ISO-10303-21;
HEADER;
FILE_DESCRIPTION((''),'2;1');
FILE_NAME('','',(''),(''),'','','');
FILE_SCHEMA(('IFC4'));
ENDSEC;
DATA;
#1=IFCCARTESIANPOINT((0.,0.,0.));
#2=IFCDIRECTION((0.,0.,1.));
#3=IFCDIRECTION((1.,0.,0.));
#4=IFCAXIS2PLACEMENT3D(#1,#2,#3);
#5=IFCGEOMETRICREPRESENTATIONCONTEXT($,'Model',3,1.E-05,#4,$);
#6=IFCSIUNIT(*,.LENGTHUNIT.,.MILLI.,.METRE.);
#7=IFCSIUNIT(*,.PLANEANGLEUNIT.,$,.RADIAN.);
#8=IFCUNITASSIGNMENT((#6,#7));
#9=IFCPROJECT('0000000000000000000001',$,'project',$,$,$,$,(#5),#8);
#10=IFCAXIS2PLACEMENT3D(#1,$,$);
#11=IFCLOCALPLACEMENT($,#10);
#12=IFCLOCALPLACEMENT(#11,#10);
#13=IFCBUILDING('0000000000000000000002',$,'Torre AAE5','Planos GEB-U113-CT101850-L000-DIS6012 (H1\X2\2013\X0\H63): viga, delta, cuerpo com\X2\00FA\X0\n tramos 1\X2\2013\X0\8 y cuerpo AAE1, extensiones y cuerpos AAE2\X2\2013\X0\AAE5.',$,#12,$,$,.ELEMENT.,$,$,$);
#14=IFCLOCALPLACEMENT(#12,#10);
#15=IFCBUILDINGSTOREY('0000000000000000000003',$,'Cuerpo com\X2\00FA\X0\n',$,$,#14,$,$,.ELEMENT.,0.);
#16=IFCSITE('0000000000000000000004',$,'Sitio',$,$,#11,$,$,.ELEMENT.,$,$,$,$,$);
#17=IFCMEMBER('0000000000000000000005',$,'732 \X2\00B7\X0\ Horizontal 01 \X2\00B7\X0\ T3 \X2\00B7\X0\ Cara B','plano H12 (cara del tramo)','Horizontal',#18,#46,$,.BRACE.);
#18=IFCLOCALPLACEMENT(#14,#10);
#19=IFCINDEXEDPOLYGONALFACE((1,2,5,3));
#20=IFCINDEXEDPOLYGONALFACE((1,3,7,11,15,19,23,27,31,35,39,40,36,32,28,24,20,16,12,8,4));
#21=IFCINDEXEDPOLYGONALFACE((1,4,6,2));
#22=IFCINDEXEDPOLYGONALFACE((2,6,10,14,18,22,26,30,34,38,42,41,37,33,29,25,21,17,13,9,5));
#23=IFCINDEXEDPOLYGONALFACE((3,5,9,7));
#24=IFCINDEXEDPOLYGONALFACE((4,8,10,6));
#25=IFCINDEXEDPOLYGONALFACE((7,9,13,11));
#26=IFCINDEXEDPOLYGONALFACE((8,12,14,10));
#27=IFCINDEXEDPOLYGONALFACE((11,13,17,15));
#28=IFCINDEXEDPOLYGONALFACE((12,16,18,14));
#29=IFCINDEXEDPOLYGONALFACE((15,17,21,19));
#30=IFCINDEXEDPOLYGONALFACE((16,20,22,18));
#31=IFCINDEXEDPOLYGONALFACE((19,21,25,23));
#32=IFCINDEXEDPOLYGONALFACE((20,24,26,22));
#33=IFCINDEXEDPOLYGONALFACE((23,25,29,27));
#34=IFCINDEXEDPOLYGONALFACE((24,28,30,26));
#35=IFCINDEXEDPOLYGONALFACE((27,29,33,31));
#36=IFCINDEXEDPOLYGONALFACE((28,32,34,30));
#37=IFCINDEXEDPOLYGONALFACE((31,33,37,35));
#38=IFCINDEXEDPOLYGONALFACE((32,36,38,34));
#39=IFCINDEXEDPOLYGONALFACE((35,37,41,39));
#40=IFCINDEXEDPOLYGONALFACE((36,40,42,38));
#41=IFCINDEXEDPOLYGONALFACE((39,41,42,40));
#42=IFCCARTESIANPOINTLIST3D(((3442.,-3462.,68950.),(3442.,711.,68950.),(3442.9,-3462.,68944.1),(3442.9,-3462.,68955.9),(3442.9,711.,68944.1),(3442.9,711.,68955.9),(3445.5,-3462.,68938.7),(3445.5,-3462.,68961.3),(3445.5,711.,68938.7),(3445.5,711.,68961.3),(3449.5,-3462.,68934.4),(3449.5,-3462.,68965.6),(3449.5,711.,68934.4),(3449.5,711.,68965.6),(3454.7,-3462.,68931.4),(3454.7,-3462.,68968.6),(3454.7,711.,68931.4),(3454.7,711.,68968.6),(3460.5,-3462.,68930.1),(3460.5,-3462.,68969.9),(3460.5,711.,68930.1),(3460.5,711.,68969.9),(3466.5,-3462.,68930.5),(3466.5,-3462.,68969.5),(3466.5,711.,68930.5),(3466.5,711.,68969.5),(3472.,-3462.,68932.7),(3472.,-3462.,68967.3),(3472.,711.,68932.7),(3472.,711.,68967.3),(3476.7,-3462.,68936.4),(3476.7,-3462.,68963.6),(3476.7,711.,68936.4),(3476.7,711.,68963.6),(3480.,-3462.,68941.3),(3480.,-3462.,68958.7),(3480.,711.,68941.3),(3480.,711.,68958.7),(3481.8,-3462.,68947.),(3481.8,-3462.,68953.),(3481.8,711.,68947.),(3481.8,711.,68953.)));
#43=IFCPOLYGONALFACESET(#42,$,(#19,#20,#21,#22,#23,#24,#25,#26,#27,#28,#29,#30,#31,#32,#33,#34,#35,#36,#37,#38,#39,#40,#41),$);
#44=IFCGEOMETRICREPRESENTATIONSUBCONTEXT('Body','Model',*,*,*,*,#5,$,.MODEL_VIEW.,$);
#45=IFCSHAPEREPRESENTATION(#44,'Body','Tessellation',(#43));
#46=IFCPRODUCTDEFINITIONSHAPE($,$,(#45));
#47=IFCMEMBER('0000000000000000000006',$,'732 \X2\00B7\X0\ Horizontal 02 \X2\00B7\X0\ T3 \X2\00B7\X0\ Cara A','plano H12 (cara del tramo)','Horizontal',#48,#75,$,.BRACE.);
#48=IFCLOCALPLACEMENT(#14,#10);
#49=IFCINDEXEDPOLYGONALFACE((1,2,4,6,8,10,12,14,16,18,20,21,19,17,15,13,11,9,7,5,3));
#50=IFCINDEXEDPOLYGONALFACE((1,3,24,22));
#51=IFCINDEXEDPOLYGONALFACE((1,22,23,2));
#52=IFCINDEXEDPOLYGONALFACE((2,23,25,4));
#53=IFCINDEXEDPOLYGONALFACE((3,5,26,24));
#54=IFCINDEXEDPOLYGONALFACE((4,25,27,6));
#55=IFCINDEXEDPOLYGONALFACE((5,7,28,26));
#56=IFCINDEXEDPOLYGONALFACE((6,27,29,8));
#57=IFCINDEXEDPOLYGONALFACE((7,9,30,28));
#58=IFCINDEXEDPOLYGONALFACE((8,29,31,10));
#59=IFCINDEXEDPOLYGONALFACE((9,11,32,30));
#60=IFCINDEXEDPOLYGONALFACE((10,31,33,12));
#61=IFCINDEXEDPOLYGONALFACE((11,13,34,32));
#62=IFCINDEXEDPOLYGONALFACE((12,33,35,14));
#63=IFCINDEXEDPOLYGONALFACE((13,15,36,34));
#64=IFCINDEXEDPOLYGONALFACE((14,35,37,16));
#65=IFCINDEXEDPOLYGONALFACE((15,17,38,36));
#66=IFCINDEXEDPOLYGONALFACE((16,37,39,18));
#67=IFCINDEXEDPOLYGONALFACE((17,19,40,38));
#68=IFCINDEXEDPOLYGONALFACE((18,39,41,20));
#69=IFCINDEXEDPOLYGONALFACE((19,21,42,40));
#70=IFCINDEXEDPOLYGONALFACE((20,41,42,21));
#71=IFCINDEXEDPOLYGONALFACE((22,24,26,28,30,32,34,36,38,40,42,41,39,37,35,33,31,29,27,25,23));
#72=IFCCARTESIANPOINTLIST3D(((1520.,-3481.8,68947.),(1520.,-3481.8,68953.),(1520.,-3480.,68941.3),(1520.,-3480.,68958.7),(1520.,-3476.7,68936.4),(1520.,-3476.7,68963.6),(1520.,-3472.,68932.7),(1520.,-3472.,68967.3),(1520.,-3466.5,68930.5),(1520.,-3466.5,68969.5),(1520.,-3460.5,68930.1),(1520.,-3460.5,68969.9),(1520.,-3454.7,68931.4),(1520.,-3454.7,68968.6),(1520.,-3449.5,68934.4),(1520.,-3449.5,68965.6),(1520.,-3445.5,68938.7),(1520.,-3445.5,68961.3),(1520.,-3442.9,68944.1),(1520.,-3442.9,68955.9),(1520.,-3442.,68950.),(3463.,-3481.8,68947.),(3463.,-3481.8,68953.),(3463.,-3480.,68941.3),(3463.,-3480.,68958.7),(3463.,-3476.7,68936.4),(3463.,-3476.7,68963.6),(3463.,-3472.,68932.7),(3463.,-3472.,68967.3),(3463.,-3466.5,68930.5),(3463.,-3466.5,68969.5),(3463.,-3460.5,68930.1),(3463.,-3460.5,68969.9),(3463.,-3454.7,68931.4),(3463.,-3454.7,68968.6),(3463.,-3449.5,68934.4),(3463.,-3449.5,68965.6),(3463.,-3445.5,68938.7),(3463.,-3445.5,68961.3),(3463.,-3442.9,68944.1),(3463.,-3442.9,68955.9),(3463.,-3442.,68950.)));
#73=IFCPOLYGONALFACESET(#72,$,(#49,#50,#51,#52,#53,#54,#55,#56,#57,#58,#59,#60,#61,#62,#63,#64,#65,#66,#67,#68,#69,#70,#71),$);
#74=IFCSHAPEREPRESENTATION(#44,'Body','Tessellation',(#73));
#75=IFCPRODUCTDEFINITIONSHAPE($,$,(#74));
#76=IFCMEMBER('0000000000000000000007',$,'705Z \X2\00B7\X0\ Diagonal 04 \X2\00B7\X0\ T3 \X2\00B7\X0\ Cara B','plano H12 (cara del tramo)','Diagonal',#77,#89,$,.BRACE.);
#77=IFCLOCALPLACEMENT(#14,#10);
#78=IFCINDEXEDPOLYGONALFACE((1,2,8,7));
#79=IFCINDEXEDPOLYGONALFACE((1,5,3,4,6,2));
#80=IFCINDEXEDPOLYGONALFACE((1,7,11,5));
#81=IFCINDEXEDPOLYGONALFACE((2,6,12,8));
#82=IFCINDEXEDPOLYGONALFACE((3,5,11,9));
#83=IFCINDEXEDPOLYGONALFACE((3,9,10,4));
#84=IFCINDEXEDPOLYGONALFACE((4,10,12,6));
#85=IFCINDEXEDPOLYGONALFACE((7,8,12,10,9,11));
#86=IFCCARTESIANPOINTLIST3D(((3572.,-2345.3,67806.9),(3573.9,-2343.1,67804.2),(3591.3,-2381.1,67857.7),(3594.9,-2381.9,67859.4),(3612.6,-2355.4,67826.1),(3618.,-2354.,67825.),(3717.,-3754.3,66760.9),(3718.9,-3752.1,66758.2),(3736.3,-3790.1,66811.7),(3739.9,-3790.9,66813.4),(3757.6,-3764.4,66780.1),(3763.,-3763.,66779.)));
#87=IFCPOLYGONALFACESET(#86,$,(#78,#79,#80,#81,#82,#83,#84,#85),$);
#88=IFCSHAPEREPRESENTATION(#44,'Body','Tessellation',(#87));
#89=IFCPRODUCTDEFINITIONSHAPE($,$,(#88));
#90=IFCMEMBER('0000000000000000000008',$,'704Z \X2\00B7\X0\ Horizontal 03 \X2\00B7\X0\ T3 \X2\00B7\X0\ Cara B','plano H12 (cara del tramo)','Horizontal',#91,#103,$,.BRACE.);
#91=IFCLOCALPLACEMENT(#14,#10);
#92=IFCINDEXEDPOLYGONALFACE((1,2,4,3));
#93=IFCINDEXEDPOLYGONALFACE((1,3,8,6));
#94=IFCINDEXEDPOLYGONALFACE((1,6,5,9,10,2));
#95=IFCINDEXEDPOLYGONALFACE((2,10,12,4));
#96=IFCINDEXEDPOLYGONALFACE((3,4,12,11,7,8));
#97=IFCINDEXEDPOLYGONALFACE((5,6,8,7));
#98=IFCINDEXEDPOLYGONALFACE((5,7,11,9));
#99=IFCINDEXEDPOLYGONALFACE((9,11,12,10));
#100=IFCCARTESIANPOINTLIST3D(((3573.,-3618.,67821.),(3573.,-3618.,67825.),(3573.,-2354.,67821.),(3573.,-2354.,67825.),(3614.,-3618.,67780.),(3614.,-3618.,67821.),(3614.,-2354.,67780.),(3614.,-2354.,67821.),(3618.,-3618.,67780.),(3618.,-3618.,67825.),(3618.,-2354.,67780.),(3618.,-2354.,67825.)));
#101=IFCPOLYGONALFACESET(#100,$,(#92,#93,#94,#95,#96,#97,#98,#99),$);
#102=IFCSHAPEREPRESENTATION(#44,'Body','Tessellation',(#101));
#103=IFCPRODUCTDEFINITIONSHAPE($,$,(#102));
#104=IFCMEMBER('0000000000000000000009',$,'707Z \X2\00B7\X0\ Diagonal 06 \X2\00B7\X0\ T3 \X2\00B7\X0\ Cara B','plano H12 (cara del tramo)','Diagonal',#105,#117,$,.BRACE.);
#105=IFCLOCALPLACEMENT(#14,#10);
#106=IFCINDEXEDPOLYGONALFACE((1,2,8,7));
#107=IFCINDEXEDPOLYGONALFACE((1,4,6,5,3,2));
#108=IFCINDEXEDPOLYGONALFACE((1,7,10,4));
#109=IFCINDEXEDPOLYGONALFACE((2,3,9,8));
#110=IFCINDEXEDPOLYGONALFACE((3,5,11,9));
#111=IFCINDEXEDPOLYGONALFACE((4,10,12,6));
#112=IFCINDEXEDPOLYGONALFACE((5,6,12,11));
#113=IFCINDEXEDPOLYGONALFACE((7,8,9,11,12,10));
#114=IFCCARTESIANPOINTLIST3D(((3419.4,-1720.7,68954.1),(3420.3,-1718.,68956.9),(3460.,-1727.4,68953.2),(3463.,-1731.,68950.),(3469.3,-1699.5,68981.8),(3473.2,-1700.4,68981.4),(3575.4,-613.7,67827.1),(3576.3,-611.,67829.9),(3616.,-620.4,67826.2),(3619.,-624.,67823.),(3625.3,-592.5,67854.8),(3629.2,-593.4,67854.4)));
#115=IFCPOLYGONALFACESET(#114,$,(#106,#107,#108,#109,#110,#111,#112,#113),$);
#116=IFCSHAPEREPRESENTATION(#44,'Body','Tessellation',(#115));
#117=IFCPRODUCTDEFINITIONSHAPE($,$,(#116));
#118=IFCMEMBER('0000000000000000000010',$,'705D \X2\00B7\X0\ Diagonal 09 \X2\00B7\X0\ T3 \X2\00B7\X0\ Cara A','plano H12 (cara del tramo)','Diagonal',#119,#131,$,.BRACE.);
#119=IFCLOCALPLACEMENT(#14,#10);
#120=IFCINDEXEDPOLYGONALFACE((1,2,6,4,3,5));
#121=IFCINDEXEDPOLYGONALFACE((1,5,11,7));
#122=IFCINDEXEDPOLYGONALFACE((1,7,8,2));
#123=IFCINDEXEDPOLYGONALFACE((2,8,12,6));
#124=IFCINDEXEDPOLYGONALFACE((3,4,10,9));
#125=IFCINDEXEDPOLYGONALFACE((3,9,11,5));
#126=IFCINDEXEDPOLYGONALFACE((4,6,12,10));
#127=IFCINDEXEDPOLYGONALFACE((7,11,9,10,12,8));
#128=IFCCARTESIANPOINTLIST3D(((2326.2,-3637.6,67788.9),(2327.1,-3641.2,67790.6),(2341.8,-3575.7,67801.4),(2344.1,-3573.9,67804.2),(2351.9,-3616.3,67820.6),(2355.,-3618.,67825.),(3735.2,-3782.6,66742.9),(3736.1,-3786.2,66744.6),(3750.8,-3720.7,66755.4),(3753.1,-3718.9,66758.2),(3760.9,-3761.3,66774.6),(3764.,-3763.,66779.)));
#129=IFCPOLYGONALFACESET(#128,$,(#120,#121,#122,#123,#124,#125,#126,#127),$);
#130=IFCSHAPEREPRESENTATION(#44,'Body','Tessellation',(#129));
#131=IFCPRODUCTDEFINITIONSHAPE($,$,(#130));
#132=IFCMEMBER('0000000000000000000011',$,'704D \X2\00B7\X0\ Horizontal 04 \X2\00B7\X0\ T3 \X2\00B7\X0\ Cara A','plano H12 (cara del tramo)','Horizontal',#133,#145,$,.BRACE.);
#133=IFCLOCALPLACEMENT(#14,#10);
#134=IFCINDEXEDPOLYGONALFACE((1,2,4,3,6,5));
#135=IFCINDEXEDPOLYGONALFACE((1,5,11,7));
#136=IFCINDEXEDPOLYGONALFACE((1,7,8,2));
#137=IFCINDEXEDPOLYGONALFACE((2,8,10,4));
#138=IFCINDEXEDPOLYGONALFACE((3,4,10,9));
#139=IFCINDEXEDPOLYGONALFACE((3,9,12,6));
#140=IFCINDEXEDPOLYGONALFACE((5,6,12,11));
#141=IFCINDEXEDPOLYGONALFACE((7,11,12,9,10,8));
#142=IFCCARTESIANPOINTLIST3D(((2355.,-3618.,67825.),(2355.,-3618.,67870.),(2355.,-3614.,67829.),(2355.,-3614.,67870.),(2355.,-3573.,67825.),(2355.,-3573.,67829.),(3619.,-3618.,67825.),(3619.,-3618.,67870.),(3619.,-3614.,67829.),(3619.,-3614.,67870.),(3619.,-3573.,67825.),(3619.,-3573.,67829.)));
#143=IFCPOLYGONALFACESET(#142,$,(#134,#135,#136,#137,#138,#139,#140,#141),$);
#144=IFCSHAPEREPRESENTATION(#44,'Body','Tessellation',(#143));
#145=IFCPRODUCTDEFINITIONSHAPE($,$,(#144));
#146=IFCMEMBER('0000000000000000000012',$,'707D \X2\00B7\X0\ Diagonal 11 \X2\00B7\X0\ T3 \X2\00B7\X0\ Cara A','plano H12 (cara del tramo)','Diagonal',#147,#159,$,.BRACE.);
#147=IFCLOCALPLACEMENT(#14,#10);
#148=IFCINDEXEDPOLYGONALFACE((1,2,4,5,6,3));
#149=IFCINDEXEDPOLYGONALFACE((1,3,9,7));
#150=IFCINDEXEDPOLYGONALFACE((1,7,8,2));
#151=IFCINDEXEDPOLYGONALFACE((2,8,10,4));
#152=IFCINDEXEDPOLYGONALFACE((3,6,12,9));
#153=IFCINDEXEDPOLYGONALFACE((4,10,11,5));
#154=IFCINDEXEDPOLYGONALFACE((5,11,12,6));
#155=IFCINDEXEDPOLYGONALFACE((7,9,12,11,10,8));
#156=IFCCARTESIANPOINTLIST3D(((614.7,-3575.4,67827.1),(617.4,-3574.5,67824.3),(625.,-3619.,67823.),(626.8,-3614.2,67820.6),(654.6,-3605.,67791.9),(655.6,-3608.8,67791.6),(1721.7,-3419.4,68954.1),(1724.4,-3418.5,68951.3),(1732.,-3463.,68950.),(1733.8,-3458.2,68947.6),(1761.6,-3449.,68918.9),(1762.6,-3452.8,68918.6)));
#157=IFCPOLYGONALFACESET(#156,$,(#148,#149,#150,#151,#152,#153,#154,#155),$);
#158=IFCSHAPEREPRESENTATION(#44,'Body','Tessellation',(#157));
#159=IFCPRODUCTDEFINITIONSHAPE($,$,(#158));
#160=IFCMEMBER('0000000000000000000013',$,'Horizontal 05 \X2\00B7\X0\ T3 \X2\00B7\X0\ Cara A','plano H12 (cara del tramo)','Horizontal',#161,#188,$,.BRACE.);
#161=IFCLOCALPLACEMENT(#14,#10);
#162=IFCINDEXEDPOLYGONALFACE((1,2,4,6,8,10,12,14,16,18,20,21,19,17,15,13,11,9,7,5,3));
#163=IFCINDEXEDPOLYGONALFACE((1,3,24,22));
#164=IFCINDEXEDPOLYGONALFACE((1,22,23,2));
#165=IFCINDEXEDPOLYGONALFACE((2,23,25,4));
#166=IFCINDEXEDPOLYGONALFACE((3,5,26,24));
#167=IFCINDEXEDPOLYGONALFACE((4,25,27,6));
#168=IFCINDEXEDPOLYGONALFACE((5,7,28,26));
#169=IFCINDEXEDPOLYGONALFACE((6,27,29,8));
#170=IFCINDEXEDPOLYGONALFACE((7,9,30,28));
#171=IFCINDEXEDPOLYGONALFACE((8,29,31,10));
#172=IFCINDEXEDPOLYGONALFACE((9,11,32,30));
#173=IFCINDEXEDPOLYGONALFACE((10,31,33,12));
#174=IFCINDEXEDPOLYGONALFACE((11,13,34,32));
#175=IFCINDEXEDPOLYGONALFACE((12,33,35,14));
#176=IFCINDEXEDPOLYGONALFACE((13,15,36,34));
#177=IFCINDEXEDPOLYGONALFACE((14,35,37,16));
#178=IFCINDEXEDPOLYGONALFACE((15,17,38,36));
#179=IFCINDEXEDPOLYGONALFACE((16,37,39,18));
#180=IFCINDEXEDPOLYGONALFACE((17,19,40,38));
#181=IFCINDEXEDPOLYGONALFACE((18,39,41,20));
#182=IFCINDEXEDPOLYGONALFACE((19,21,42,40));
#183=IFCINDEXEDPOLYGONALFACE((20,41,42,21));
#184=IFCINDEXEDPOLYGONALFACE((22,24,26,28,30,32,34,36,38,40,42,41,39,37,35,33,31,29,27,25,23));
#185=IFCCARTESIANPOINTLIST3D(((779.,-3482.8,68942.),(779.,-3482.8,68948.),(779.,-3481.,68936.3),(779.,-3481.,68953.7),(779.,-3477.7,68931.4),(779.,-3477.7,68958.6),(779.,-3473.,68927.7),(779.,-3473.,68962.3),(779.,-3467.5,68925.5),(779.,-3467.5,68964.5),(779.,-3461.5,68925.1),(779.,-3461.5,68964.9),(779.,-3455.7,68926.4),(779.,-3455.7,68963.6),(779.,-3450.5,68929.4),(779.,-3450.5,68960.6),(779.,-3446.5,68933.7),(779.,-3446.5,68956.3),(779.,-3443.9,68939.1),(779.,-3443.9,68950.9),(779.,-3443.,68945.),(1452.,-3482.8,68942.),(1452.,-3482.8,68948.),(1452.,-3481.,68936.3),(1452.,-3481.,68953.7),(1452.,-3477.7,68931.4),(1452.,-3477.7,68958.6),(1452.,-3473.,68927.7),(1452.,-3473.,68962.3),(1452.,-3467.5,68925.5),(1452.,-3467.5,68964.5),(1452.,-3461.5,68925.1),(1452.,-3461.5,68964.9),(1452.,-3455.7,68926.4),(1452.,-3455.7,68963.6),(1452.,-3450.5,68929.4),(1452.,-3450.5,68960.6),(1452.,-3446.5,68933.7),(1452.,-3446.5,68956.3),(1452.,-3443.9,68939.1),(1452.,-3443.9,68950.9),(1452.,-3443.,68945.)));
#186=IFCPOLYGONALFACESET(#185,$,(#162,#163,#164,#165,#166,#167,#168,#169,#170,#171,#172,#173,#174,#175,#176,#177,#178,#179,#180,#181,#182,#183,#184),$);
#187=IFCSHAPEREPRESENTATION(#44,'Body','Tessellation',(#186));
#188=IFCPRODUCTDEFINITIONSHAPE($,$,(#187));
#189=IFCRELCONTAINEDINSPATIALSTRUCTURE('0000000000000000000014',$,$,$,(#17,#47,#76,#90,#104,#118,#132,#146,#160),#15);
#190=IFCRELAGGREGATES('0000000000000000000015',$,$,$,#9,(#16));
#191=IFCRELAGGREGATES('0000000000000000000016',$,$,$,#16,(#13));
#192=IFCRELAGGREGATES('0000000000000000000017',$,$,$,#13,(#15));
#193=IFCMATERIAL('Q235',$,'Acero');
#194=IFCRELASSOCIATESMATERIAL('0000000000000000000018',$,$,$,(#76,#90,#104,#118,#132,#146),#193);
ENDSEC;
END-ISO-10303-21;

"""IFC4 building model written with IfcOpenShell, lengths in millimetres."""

from ifc_helpers import new_model, si_unit, frame, frame_2d, origin, origin_with_axes, place, context, subcontext, project, spatial, circle, l_section, extrude, material, element, save


model = new_model("IFC4")

# Units and contexts
model_context = context("Model", 3, precision=1e-05, world=origin_with_axes())
body_context = subcontext(model_context, "Body", "Model", "MODEL_VIEW")
ifc_project = project(units=[si_unit("LENGTHUNIT", "METRE", prefix="MILLI"), si_unit("PLANEANGLEUNIT", "RADIAN")], contexts=[model_context])

# Site, building, storey
site_placement = place(None, origin())
site = spatial("IfcSite", under=ifc_project, at=site_placement, Name="Sitio", CompositionType="ELEMENT")
building_placement = place(site_placement, origin())
building = spatial("IfcBuilding", under=site, at=building_placement, Name="Torre AAE5", Description="Planos GEB-U113-CT101850-L000-DIS6012 (H1–H63): viga, delta, cuerpo común tramos 1–8 y cuerpo AAE1, extensiones y cuerpos AAE2–AAE5.", CompositionType="ELEMENT")
storey_placement = place(building_placement, origin())
storey = spatial("IfcBuildingStorey", under=building, at=storey_placement, Name="Cuerpo común", CompositionType="ELEMENT", Elevation=0.0)

# Members
ifc_material_1 = material(Name="Q235", Category="Acero")
member_1_placement = place(storey_placement, frame((3462.0, -3462.0, 68950.0), z_axis=(0.0, 1.0, 0.0), x_axis=(-1.0, 0.0, 0.0)))
element("IfcMember", 1, at=member_1_placement, inside=storey, Name="732 · Horizontal 01 · T3 · Cara B", Description="plano H12 (cara del tramo)", ObjectType="Horizontal", PredefinedType="BRACE", context=body_context, shape_type="SweptSolid", body=[
    extrude(circle(Radius=20.0), None, (0.0, 0.0, 1.0), 4173.0),
])
member_2_placement = place(storey_placement, frame((1520.0, -3462.0, 68950.0), z_axis=(1.0, 0.0, 0.0), x_axis=(0.0, 1.0, 0.0)))
element("IfcMember", 2, at=member_2_placement, inside=storey, Name="732 · Horizontal 02 · T3 · Cara A", Description="plano H12 (cara del tramo)", ObjectType="Horizontal", PredefinedType="BRACE", context=body_context, shape_type="SweptSolid", body=[
    extrude(circle(Radius=20.0), None, (0.0, 0.0, 1.0), 1943.0),
])
member_3_placement = place(storey_placement, frame((3763.0, -3763.0, 66779.0), z_axis=(-0.082349, 0.800204, 0.594048), x_axis=(-0.882566, 0.218321, -0.41643)))
element("IfcMember", 3, at=member_3_placement, inside=storey, material=ifc_material_1, Name="705Z · Diagonal 04 · T3 · Cara B", Description="plano H12 (cara del tramo)", ObjectType="Diagonal", PredefinedType="BRACE", context=body_context, shape_type="SweptSolid", body=[
    extrude(l_section(Depth=50.0, Width=50.0, Thickness=4.0, at=frame_2d((25.0, 25.0))), None, (0.0, 0.0, 1.0), 1760.8),
])
member_4_placement = place(storey_placement, frame((3618.0, -2354.0, 67825.0), z_axis=(0.0, -1.0, 0.0), x_axis=(-1.0, 0.0, 0.0)))
element("IfcMember", 4, at=member_4_placement, inside=storey, material=ifc_material_1, Name="704Z · Horizontal 03 · T3 · Cara B", Description="plano H12 (cara del tramo)", ObjectType="Horizontal", PredefinedType="BRACE", context=body_context, shape_type="SweptSolid", body=[
    extrude(l_section(Depth=45.0, Width=45.0, Thickness=4.0, at=frame_2d((22.5, 22.5))), None, (0.0, 0.0, 1.0), 1264.0),
])
member_5_placement = place(storey_placement, frame((3463.0, -1731.0, 68950.0), z_axis=(0.098272, 0.697356, -0.709955), x_axis=(-0.969194, 0.228971, 0.090751)))
element("IfcMember", 5, at=member_5_placement, inside=storey, material=ifc_material_1, Name="707Z · Diagonal 06 · T3 · Cara B", Description="plano H12 (cara del tramo)", ObjectType="Diagonal", PredefinedType="BRACE", context=body_context, shape_type="SweptSolid", body=[
    extrude(l_section(Depth=45.0, Width=45.0, Thickness=4.0, at=frame_2d((22.5, 22.5))), None, (0.0, 0.0, 1.0), 1587.4),
])
member_6_placement = place(storey_placement, frame((3764.0, -3763.0, 66779.0), z_axis=(-0.800204, 0.082349, 0.594048), x_axis=(-0.2184, 0.8825, -0.416528)))
element("IfcMember", 6, at=member_6_placement, inside=storey, material=ifc_material_1, Name="705D · Diagonal 09 · T3 · Cara A", Description="plano H12 (cara del tramo)", ObjectType="Diagonal", PredefinedType="BRACE", context=body_context, shape_type="SweptSolid", body=[
    extrude(l_section(Depth=50.0, Width=50.0, Thickness=4.0, at=frame_2d((25.0, 25.0))), None, (0.0, 0.0, 1.0), 1760.8),
])
member_7_placement = place(storey_placement, frame((2355.0, -3618.0, 67825.0), z_axis=(1.0, 0.0, 0.0), x_axis=(0.0, 1.0, 0.0)))
element("IfcMember", 7, at=member_7_placement, inside=storey, material=ifc_material_1, Name="704D · Horizontal 04 · T3 · Cara A", Description="plano H12 (cara del tramo)", ObjectType="Horizontal", PredefinedType="BRACE", context=body_context, shape_type="SweptSolid", body=[
    extrude(l_section(Depth=45.0, Width=45.0, Thickness=4.0, at=frame_2d((22.5, 22.5))), None, (0.0, 0.0, 1.0), 1264.0),
])
member_8_placement = place(storey_placement, frame((1732.0, -3463.0, 68950.0), z_axis=(-0.697356, -0.098272, -0.709955), x_axis=(-0.229096, 0.969152, 0.090879)))
element("IfcMember", 8, at=member_8_placement, inside=storey, material=ifc_material_1, Name="707D · Diagonal 11 · T3 · Cara A", Description="plano H12 (cara del tramo)", ObjectType="Diagonal", PredefinedType="BRACE", context=body_context, shape_type="SweptSolid", body=[
    extrude(l_section(Depth=45.0, Width=45.0, Thickness=4.0, at=frame_2d((22.5, 22.5))), None, (0.0, 0.0, 1.0), 1587.4),
])
member_9_placement = place(storey_placement, frame((779.0, -3463.0, 68945.0), z_axis=(1.0, 0.0, 0.0), x_axis=(0.0, 1.0, 0.0)))
element("IfcMember", 9, at=member_9_placement, inside=storey, Name="Horizontal 05 · T3 · Cara A", Description="plano H12 (cara del tramo)", ObjectType="Horizontal", PredefinedType="BRACE", context=body_context, shape_type="SweptSolid", body=[
    extrude(circle(Radius=20.0), None, (0.0, 0.0, 1.0), 673.0),
])

save(model, "model.ifc")
